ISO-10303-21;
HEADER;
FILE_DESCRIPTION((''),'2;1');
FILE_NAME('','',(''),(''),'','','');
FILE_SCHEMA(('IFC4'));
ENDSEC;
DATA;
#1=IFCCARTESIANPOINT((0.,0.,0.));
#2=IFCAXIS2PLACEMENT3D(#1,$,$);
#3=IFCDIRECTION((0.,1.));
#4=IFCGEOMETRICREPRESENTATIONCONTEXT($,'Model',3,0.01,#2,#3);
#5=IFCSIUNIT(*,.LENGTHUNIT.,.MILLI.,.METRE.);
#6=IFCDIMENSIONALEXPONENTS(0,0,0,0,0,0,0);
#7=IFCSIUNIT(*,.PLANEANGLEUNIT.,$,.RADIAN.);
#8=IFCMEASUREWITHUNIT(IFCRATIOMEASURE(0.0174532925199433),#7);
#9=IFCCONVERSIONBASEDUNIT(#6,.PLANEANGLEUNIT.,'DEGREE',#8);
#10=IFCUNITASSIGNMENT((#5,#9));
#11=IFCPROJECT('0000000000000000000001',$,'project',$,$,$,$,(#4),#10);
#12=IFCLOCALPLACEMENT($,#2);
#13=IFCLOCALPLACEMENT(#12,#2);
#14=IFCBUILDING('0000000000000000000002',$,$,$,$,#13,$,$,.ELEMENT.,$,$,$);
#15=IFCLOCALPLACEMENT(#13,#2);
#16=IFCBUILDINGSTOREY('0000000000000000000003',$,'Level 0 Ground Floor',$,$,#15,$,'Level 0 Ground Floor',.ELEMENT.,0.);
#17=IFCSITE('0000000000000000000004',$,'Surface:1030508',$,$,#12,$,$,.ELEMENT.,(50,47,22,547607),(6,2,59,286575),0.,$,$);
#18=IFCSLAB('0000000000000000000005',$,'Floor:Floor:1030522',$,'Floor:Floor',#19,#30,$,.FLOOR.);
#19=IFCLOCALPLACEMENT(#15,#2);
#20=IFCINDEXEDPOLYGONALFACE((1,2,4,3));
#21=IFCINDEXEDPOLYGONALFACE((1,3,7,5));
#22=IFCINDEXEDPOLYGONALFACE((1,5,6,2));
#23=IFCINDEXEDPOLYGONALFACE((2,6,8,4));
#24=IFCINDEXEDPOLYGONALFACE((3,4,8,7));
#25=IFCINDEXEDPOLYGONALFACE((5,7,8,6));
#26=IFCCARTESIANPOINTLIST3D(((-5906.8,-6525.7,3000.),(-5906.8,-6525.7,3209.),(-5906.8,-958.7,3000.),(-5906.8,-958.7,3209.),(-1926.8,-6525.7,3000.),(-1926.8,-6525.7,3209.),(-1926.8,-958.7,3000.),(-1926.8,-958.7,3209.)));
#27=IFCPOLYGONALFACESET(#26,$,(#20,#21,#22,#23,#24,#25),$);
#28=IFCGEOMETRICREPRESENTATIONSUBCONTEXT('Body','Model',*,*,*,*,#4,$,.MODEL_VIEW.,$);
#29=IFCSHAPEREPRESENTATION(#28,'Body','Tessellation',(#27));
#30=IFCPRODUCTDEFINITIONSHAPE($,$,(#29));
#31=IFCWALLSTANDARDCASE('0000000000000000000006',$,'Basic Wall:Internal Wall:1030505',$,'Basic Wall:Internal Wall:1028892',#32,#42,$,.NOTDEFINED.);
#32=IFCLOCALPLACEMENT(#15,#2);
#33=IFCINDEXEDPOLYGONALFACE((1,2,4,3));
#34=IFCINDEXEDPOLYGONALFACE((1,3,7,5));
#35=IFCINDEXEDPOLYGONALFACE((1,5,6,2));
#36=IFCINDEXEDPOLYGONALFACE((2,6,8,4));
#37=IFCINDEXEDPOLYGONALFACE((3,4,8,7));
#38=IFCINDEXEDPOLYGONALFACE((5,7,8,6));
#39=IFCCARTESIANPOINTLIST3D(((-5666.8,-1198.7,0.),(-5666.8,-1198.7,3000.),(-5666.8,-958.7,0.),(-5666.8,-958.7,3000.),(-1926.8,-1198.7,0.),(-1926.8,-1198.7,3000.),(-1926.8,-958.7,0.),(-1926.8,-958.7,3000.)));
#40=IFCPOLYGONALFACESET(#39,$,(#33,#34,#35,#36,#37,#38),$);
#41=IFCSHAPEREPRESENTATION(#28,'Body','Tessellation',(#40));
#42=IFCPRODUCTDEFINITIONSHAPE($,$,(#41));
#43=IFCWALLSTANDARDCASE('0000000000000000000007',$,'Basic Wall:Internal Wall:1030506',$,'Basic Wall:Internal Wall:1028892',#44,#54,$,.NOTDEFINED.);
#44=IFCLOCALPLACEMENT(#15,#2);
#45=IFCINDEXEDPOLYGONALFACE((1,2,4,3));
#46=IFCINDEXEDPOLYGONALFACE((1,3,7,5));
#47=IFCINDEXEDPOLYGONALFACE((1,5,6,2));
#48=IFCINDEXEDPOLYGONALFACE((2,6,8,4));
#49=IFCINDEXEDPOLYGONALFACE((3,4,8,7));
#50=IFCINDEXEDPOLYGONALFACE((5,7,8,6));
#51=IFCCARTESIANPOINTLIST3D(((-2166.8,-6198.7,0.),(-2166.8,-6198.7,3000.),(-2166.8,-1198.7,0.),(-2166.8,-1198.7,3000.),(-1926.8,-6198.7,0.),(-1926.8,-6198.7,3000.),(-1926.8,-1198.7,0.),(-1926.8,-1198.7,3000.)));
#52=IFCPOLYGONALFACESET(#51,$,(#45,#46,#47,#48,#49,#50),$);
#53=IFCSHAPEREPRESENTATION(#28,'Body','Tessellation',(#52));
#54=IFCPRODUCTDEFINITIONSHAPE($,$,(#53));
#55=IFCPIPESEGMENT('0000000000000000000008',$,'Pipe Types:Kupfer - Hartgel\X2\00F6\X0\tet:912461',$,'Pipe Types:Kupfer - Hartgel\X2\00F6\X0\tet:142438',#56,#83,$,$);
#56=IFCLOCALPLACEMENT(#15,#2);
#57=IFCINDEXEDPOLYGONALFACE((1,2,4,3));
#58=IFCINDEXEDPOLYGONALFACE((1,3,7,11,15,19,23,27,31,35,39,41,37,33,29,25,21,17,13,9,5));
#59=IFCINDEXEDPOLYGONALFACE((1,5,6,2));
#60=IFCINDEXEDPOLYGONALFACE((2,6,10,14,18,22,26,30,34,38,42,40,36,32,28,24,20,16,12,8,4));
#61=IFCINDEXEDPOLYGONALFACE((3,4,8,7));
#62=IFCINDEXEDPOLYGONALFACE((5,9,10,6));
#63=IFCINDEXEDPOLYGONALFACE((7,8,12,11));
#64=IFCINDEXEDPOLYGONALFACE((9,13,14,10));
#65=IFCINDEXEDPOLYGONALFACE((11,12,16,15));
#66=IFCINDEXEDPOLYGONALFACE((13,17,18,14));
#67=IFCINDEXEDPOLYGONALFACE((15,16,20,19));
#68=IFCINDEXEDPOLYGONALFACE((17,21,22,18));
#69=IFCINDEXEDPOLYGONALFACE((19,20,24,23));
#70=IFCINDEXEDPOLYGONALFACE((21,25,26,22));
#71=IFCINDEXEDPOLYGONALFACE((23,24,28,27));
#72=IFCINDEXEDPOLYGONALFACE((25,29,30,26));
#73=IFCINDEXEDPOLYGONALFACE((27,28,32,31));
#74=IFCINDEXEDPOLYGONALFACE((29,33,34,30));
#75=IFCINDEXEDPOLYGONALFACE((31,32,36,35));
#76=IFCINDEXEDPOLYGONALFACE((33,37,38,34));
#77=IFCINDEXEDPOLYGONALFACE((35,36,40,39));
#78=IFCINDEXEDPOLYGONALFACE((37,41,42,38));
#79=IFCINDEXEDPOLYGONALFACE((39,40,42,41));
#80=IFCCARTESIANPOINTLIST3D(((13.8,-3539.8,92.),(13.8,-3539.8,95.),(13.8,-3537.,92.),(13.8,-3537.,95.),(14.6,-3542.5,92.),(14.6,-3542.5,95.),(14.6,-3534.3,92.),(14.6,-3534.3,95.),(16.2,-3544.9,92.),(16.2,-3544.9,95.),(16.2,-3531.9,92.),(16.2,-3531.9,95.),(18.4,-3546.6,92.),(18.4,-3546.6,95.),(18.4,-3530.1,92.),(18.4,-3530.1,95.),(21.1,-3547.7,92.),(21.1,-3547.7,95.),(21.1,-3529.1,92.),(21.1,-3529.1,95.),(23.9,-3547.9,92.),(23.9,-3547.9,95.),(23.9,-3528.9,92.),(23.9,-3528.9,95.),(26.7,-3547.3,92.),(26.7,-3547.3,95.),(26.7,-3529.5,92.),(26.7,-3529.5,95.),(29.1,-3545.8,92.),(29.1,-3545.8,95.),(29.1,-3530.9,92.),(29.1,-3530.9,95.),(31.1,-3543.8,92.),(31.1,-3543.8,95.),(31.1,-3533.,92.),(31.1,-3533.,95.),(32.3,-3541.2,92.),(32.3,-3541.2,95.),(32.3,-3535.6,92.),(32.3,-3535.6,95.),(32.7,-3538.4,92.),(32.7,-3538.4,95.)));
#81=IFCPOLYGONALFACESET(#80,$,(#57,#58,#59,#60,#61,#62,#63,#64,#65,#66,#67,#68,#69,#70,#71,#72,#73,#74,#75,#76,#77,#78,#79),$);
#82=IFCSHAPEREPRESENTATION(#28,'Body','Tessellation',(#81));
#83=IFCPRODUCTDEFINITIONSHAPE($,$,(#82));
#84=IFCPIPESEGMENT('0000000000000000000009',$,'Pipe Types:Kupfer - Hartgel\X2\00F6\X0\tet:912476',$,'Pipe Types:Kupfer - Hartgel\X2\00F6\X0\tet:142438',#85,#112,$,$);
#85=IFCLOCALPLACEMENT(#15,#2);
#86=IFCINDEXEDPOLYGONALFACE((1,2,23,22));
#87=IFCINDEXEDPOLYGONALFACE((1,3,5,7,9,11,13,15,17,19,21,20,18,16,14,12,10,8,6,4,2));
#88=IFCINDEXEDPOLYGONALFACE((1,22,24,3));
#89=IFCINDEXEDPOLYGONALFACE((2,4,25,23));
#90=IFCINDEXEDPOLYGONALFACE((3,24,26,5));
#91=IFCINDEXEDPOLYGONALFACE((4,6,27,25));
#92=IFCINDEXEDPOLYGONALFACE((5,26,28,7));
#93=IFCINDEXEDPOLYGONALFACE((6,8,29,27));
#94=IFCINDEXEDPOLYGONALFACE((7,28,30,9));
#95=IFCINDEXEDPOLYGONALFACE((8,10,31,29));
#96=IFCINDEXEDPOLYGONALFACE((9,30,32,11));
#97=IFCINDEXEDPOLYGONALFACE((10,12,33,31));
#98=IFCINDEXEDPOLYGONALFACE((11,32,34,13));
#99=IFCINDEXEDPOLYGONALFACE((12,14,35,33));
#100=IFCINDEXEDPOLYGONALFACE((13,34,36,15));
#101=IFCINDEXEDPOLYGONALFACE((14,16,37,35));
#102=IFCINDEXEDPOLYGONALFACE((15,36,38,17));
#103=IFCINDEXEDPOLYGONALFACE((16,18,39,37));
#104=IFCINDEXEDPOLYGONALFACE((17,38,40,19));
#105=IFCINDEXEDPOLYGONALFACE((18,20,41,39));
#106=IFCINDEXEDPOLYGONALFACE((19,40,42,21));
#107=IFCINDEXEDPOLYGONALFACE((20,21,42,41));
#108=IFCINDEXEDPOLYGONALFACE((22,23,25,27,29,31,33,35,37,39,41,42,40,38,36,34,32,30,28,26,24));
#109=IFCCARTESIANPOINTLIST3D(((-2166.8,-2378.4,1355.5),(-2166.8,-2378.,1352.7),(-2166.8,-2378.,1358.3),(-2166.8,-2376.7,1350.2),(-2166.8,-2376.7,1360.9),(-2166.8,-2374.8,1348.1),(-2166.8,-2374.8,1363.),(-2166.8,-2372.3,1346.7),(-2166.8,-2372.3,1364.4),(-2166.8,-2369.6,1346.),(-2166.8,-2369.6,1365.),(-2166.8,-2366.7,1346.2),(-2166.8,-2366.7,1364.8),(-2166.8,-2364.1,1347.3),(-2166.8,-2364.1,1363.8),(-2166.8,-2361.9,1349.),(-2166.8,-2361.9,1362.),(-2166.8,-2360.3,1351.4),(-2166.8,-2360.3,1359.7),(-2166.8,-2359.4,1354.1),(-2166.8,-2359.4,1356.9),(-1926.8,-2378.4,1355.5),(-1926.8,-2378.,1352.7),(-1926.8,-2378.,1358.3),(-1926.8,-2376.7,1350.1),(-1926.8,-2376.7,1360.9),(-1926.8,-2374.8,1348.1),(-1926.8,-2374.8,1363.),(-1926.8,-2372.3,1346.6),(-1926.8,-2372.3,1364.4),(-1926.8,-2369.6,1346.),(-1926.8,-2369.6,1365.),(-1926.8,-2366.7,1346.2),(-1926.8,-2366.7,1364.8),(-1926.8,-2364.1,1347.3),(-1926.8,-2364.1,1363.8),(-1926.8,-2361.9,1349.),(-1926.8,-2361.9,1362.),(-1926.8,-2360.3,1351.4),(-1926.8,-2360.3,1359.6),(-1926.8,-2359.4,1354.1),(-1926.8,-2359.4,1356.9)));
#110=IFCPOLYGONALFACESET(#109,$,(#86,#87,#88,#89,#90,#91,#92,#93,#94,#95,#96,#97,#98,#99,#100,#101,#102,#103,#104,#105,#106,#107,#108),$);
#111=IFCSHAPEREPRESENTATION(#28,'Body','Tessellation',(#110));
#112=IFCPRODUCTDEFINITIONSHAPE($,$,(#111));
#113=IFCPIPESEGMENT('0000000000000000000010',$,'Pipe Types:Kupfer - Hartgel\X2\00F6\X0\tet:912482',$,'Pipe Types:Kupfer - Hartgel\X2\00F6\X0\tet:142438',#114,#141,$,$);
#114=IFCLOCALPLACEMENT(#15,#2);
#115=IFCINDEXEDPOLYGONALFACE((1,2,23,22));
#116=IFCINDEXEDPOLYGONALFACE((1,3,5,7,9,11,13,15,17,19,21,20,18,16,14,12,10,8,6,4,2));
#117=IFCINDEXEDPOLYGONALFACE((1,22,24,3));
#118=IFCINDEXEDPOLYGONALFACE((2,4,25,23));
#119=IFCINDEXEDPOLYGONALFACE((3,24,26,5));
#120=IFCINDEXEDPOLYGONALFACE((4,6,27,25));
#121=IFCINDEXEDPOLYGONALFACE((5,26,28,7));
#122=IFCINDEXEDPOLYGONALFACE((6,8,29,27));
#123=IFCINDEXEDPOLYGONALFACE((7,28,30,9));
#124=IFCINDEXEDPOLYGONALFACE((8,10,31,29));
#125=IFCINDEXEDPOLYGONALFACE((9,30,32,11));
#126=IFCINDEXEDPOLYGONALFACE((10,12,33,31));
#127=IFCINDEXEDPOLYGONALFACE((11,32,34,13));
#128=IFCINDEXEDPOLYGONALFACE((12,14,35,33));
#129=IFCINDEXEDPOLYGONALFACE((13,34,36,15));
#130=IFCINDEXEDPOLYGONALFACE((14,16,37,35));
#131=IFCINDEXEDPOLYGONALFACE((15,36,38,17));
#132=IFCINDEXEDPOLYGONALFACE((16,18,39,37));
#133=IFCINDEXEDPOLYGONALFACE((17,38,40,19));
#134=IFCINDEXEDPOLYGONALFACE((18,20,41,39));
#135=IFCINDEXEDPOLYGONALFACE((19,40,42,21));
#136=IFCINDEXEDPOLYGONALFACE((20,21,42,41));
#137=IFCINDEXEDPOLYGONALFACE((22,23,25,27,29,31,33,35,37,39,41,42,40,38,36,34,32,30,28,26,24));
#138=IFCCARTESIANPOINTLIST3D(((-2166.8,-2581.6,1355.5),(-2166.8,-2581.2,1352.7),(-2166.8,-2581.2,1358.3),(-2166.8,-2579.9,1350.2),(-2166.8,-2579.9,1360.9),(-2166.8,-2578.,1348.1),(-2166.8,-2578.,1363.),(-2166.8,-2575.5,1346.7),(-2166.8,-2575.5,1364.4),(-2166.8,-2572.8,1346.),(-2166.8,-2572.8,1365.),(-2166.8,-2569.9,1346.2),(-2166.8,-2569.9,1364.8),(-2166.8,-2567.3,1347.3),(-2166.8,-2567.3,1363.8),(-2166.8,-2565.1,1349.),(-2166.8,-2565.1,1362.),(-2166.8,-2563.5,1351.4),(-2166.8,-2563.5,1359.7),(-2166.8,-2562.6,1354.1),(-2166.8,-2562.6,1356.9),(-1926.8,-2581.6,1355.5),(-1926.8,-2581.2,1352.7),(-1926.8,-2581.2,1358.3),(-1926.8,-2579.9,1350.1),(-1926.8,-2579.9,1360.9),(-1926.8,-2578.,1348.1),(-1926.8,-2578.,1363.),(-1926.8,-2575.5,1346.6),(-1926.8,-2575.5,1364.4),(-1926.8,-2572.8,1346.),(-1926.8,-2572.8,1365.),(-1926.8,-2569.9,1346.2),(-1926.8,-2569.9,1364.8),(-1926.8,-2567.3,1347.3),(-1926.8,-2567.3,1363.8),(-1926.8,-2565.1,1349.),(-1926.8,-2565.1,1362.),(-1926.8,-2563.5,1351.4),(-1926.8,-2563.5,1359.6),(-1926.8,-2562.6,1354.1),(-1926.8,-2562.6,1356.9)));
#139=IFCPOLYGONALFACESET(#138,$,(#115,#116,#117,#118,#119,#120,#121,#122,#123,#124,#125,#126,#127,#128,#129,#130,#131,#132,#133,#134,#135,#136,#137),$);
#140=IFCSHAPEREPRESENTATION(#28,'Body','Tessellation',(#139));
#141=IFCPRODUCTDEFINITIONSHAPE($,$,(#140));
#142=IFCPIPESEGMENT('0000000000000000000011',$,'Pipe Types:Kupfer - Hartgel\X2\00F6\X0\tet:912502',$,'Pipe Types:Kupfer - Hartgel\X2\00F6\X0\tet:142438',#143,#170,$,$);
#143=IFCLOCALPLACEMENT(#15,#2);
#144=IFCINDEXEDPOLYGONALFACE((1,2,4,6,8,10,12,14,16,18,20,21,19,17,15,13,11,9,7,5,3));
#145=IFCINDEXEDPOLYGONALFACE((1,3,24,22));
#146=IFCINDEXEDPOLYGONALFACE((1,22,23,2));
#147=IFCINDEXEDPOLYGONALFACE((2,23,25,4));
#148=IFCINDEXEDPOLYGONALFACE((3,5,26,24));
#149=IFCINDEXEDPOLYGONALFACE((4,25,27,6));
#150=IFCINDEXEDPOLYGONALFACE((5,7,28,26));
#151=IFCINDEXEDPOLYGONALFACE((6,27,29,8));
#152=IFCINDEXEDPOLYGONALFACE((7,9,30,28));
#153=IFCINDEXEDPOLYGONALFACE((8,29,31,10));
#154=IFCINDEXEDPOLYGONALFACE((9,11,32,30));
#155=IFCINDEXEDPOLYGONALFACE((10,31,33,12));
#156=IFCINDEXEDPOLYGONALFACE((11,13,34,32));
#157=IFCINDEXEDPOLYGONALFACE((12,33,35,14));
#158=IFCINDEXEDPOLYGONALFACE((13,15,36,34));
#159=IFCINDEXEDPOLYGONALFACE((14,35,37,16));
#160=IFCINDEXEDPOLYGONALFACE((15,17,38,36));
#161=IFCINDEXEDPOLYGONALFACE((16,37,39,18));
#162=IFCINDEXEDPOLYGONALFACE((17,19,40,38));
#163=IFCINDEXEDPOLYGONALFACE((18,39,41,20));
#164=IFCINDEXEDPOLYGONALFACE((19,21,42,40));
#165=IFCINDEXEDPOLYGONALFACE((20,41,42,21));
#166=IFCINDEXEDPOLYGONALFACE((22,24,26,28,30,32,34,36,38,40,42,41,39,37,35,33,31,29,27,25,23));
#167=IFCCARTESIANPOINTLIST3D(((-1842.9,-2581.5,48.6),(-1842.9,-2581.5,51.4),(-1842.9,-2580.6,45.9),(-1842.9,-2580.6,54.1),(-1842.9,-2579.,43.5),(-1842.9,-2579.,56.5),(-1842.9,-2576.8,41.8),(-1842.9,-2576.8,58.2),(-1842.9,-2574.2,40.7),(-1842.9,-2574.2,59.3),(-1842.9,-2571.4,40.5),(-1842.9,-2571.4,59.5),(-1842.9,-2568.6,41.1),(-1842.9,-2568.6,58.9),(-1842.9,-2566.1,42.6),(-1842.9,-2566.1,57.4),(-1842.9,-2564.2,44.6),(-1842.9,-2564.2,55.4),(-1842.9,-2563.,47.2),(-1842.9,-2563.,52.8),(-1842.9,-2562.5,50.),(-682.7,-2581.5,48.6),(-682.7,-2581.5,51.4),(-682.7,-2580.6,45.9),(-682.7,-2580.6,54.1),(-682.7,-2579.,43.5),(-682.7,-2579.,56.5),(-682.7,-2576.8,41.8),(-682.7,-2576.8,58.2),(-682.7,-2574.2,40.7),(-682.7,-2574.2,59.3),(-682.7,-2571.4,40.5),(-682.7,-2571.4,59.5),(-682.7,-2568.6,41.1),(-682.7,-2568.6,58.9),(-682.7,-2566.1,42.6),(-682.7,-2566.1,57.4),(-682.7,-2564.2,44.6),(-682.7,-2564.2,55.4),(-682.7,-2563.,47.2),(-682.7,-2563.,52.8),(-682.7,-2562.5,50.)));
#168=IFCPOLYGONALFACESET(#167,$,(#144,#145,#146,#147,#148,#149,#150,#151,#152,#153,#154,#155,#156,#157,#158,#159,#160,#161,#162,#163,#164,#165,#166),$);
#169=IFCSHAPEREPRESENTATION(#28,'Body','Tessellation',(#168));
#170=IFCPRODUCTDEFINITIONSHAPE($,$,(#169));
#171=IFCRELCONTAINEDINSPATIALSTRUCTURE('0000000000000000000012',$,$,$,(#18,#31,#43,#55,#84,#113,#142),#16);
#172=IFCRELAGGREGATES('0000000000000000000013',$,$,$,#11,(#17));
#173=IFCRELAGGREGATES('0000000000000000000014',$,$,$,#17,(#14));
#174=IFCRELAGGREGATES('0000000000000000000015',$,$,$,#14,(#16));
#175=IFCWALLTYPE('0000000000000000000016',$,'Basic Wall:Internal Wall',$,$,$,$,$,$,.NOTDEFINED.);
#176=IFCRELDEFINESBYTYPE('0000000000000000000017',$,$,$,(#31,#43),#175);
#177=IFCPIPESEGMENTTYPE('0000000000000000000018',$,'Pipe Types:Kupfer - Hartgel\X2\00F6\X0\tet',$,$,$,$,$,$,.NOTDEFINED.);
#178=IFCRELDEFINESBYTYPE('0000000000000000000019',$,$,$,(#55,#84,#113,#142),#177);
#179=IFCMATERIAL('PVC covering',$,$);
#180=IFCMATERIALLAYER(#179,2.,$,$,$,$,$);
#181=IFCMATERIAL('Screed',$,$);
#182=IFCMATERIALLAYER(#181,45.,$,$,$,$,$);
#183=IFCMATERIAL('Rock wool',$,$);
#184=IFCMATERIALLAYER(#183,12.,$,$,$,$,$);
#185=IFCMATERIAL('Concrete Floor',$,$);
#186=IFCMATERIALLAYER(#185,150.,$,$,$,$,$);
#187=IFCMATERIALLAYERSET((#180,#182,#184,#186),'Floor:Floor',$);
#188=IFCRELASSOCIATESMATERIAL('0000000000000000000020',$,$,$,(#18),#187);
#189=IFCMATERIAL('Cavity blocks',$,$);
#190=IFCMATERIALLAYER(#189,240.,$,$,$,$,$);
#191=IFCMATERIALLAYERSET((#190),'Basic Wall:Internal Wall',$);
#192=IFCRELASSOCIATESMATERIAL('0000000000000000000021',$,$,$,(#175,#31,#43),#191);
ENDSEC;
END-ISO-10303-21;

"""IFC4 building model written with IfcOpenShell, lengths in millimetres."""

from ifc_helpers import new_model, entity, si_unit, converted_unit, direction, frame, frame_2d, origin, origin_2d_with_axis, place, context, subcontext, project, spatial, polyline, rectangle, circle, extrude, clip, bounded_halfspace, material, layer, layer_set, layer_usage, type_object, element, save


model = new_model("IFC4")

# Units and contexts
model_context = context("Model", 3, precision=0.01, world=origin(), true_north=direction((0.0, 1.0)))
body_context = subcontext(model_context, "Body", "Model", "MODEL_VIEW")
ifc_project = project(units=[si_unit("LENGTHUNIT", "METRE", prefix="MILLI"), converted_unit("PLANEANGLEUNIT", "DEGREE", entity("IfcRatioMeasure", 0.0174532925199433), si_unit("PLANEANGLEUNIT", "RADIAN"), dimensions=[0, 0, 0, 0, 0, 0, 0])], contexts=[model_context])

# Site, building, storey
site_placement = place(None, origin())
site = spatial("IfcSite", under=ifc_project, at=site_placement, Name="Surface:1030508", CompositionType="ELEMENT", RefLatitude=(50, 47, 22, 547607), RefLongitude=(6, 2, 59, 286575), RefElevation=0.0)
building_placement = place(site_placement, origin())
building = spatial("IfcBuilding", under=site, at=building_placement, CompositionType="ELEMENT")
storey_placement = place(building_placement, origin())
storey = spatial("IfcBuildingStorey", under=building, at=storey_placement, Name="Level 0 Ground Floor", LongName="Level 0 Ground Floor", CompositionType="ELEMENT", Elevation=0.0)

# Slab
ifc_material_1 = material(Name="PVC covering")
ifc_layer_1 = layer(ifc_material_1, 2.0)
ifc_material_2 = material(Name="Screed")
ifc_layer_2 = layer(ifc_material_2, 45.0)
ifc_material_3 = material(Name="Rock wool")
ifc_layer_3 = layer(ifc_material_3, 12.0)
ifc_material_4 = material(Name="Concrete Floor")
ifc_layer_4 = layer(ifc_material_4, 150.0)
ifc_layer_set_1 = layer_set([ifc_layer_1, ifc_layer_2, ifc_layer_3, ifc_layer_4], Name="Floor:Floor")
ifc_layer_usage_1 = layer_usage(ifc_layer_set_1, "AXIS3", "POSITIVE", 0.0)
slab_placement = place(storey_placement, origin())
element("IfcSlab", 1, at=slab_placement, inside=storey, material=ifc_layer_usage_1, Name="Floor:Floor:1030522", ObjectType="Floor:Floor", PredefinedType="FLOOR", context=body_context, shape_type="SweptSolid", body=[
    extrude(rectangle(XDim=5567.0, YDim=3980.0, at=frame_2d((0.0, 0.0), x_axis=(1.0, 0.0))), frame((-3916.8, -3742.2, 3209.0), z_axis=(0.0, 0.0, -1.0), x_axis=(0.0, 1.0, 0.0)), (0.0, 0.0, 1.0), 209.0),
])

# Walls
ifc_material_5 = material(Name="Cavity blocks")
ifc_layer_5 = layer(ifc_material_5, 240.0)
ifc_layer_set_2 = layer_set([ifc_layer_5], Name="Basic Wall:Internal Wall")
ifc_layer_usage_2 = layer_usage(ifc_layer_set_2, "AXIS2", "NEGATIVE", 120.0)
wall_type = type_object("IfcWallType", Name="Basic Wall:Internal Wall", PredefinedType="NOTDEFINED", material=ifc_layer_set_2)
wall_1_placement = place(storey_placement, frame((-5666.8, -1078.7, 0.0)))
element("IfcWallStandardCase", 2, at=wall_1_placement, inside=storey, type_object=wall_type, material=ifc_layer_usage_2, Name="Basic Wall:Internal Wall:1030505", ObjectType="Basic Wall:Internal Wall:1028892", PredefinedType="NOTDEFINED", context=body_context, shape_type="Clipping", body=[
    clip(extrude(rectangle(XDim=3740.0, YDim=240.0, at=frame_2d((1870.0, 0.0), x_axis=(-1.0, 0.0))), origin(), (0.0, 0.0, 1.0), 3000.0), bounded_halfspace(frame((0.0, -120.0, 3000.0), z_axis=(0.0, 0.0, -1.0), x_axis=(0.0, -1.0, 0.0)), True, frame((0.0, -120.0, 3000.0)), polyline([(0.0, 0.0), (3500.0, 0.0), (3740.0, 0.0), (3740.0, 240.0), (0.0, 240.0), (0.0, 0.0)]))),
])
ifc_layer_usage_3 = layer_usage(ifc_layer_set_2, "AXIS2", "NEGATIVE", 120.0)
wall_2_placement = place(storey_placement, frame((-2046.8, -1198.7, 0.0), z_axis=(0.0, 0.0, 1.0), x_axis=(0.0, -1.0, 0.0)))
element("IfcWallStandardCase", 3, at=wall_2_placement, inside=storey, type_object=wall_type, material=ifc_layer_usage_3, Name="Basic Wall:Internal Wall:1030506", ObjectType="Basic Wall:Internal Wall:1028892", PredefinedType="NOTDEFINED", context=body_context, shape_type="Clipping", body=[
    clip(extrude(rectangle(XDim=5000.0, YDim=240.0, at=frame_2d((2500.0, 0.0), x_axis=(-1.0, 0.0))), origin(), (0.0, 0.0, 1.0), 3000.0), bounded_halfspace(frame((0.0, -120.0, 3000.0), z_axis=(0.0, 0.0, -1.0), x_axis=(1.0, 0.0, 0.0)), True, frame((0.0, -120.0, 3000.0)), polyline([(0.0, 0.0), (5000.0, 0.0), (5000.0, 240.0), (0.0, 240.0), (0.0, 0.0)]))),
])

# Pipe segments
pipe_segment_type = type_object("IfcPipeSegmentType", Name="Pipe Types:Kupfer - Hartgelötet", PredefinedType="NOTDEFINED")
pipe_segment_1_placement = place(storey_placement, frame((12.1, -3549.5, 92.0)))
element("IfcPipeSegment", 4, at=pipe_segment_1_placement, inside=storey, type_object=pipe_segment_type, Name="Pipe Types:Kupfer - Hartgelötet:912461", ObjectType="Pipe Types:Kupfer - Hartgelötet:142438", context=body_context, shape_type="SweptSolid", body=[
    extrude(circle(Radius=9.5, at=frame_2d((0.0, 0.0), x_axis=(1.0, 0.0))), frame((11.1, 11.1, 0.0)), (0.0, 0.0, 1.0), 3.0),
])
pipe_segment_2_placement = place(storey_placement, frame((-2166.8, -2380.0, 1344.4)))
element("IfcPipeSegment", 5, at=pipe_segment_2_placement, inside=storey, type_object=pipe_segment_type, Name="Pipe Types:Kupfer - Hartgelötet:912476", ObjectType="Pipe Types:Kupfer - Hartgelötet:142438", context=body_context, shape_type="SweptSolid", body=[
    extrude(circle(Radius=9.5, at=origin_2d_with_axis()), frame((0.0, 11.1, 11.1), z_axis=(1.0, 0.0, -0.000089), x_axis=(0.0, -1.0, 0.0)), (0.0, 0.0, 1.0), 240.0),
])
pipe_segment_3_placement = place(storey_placement, frame((-2166.8, -2583.2, 1344.4)))
element("IfcPipeSegment", 6, at=pipe_segment_3_placement, inside=storey, type_object=pipe_segment_type, Name="Pipe Types:Kupfer - Hartgelötet:912482", ObjectType="Pipe Types:Kupfer - Hartgelötet:142438", context=body_context, shape_type="SweptSolid", body=[
    extrude(circle(Radius=9.5, at=origin_2d_with_axis()), frame((240.0, 11.1, 11.1), z_axis=(-1.0, 0.0, 0.000076), x_axis=(0.0, -1.0, 0.0)), (0.0, 0.0, 1.0), 240.0),
])
pipe_segment_4_placement = place(storey_placement, frame((-1842.9, -2583.2, 38.9)))
element("IfcPipeSegment", 7, at=pipe_segment_4_placement, inside=storey, type_object=pipe_segment_type, Name="Pipe Types:Kupfer - Hartgelötet:912502", ObjectType="Pipe Types:Kupfer - Hartgelötet:142438", context=body_context, shape_type="SweptSolid", body=[
    extrude(circle(Radius=9.5, at=frame_2d((0.0, 0.0), x_axis=(1.0, 0.0))), frame((0.0, 11.1, 11.1), z_axis=(1.0, 0.000001, 0.0), x_axis=(-0.000001, 1.0, 0.0)), (0.0, 0.0, 1.0), 1160.2),
])

save(model, "model.ifc")
